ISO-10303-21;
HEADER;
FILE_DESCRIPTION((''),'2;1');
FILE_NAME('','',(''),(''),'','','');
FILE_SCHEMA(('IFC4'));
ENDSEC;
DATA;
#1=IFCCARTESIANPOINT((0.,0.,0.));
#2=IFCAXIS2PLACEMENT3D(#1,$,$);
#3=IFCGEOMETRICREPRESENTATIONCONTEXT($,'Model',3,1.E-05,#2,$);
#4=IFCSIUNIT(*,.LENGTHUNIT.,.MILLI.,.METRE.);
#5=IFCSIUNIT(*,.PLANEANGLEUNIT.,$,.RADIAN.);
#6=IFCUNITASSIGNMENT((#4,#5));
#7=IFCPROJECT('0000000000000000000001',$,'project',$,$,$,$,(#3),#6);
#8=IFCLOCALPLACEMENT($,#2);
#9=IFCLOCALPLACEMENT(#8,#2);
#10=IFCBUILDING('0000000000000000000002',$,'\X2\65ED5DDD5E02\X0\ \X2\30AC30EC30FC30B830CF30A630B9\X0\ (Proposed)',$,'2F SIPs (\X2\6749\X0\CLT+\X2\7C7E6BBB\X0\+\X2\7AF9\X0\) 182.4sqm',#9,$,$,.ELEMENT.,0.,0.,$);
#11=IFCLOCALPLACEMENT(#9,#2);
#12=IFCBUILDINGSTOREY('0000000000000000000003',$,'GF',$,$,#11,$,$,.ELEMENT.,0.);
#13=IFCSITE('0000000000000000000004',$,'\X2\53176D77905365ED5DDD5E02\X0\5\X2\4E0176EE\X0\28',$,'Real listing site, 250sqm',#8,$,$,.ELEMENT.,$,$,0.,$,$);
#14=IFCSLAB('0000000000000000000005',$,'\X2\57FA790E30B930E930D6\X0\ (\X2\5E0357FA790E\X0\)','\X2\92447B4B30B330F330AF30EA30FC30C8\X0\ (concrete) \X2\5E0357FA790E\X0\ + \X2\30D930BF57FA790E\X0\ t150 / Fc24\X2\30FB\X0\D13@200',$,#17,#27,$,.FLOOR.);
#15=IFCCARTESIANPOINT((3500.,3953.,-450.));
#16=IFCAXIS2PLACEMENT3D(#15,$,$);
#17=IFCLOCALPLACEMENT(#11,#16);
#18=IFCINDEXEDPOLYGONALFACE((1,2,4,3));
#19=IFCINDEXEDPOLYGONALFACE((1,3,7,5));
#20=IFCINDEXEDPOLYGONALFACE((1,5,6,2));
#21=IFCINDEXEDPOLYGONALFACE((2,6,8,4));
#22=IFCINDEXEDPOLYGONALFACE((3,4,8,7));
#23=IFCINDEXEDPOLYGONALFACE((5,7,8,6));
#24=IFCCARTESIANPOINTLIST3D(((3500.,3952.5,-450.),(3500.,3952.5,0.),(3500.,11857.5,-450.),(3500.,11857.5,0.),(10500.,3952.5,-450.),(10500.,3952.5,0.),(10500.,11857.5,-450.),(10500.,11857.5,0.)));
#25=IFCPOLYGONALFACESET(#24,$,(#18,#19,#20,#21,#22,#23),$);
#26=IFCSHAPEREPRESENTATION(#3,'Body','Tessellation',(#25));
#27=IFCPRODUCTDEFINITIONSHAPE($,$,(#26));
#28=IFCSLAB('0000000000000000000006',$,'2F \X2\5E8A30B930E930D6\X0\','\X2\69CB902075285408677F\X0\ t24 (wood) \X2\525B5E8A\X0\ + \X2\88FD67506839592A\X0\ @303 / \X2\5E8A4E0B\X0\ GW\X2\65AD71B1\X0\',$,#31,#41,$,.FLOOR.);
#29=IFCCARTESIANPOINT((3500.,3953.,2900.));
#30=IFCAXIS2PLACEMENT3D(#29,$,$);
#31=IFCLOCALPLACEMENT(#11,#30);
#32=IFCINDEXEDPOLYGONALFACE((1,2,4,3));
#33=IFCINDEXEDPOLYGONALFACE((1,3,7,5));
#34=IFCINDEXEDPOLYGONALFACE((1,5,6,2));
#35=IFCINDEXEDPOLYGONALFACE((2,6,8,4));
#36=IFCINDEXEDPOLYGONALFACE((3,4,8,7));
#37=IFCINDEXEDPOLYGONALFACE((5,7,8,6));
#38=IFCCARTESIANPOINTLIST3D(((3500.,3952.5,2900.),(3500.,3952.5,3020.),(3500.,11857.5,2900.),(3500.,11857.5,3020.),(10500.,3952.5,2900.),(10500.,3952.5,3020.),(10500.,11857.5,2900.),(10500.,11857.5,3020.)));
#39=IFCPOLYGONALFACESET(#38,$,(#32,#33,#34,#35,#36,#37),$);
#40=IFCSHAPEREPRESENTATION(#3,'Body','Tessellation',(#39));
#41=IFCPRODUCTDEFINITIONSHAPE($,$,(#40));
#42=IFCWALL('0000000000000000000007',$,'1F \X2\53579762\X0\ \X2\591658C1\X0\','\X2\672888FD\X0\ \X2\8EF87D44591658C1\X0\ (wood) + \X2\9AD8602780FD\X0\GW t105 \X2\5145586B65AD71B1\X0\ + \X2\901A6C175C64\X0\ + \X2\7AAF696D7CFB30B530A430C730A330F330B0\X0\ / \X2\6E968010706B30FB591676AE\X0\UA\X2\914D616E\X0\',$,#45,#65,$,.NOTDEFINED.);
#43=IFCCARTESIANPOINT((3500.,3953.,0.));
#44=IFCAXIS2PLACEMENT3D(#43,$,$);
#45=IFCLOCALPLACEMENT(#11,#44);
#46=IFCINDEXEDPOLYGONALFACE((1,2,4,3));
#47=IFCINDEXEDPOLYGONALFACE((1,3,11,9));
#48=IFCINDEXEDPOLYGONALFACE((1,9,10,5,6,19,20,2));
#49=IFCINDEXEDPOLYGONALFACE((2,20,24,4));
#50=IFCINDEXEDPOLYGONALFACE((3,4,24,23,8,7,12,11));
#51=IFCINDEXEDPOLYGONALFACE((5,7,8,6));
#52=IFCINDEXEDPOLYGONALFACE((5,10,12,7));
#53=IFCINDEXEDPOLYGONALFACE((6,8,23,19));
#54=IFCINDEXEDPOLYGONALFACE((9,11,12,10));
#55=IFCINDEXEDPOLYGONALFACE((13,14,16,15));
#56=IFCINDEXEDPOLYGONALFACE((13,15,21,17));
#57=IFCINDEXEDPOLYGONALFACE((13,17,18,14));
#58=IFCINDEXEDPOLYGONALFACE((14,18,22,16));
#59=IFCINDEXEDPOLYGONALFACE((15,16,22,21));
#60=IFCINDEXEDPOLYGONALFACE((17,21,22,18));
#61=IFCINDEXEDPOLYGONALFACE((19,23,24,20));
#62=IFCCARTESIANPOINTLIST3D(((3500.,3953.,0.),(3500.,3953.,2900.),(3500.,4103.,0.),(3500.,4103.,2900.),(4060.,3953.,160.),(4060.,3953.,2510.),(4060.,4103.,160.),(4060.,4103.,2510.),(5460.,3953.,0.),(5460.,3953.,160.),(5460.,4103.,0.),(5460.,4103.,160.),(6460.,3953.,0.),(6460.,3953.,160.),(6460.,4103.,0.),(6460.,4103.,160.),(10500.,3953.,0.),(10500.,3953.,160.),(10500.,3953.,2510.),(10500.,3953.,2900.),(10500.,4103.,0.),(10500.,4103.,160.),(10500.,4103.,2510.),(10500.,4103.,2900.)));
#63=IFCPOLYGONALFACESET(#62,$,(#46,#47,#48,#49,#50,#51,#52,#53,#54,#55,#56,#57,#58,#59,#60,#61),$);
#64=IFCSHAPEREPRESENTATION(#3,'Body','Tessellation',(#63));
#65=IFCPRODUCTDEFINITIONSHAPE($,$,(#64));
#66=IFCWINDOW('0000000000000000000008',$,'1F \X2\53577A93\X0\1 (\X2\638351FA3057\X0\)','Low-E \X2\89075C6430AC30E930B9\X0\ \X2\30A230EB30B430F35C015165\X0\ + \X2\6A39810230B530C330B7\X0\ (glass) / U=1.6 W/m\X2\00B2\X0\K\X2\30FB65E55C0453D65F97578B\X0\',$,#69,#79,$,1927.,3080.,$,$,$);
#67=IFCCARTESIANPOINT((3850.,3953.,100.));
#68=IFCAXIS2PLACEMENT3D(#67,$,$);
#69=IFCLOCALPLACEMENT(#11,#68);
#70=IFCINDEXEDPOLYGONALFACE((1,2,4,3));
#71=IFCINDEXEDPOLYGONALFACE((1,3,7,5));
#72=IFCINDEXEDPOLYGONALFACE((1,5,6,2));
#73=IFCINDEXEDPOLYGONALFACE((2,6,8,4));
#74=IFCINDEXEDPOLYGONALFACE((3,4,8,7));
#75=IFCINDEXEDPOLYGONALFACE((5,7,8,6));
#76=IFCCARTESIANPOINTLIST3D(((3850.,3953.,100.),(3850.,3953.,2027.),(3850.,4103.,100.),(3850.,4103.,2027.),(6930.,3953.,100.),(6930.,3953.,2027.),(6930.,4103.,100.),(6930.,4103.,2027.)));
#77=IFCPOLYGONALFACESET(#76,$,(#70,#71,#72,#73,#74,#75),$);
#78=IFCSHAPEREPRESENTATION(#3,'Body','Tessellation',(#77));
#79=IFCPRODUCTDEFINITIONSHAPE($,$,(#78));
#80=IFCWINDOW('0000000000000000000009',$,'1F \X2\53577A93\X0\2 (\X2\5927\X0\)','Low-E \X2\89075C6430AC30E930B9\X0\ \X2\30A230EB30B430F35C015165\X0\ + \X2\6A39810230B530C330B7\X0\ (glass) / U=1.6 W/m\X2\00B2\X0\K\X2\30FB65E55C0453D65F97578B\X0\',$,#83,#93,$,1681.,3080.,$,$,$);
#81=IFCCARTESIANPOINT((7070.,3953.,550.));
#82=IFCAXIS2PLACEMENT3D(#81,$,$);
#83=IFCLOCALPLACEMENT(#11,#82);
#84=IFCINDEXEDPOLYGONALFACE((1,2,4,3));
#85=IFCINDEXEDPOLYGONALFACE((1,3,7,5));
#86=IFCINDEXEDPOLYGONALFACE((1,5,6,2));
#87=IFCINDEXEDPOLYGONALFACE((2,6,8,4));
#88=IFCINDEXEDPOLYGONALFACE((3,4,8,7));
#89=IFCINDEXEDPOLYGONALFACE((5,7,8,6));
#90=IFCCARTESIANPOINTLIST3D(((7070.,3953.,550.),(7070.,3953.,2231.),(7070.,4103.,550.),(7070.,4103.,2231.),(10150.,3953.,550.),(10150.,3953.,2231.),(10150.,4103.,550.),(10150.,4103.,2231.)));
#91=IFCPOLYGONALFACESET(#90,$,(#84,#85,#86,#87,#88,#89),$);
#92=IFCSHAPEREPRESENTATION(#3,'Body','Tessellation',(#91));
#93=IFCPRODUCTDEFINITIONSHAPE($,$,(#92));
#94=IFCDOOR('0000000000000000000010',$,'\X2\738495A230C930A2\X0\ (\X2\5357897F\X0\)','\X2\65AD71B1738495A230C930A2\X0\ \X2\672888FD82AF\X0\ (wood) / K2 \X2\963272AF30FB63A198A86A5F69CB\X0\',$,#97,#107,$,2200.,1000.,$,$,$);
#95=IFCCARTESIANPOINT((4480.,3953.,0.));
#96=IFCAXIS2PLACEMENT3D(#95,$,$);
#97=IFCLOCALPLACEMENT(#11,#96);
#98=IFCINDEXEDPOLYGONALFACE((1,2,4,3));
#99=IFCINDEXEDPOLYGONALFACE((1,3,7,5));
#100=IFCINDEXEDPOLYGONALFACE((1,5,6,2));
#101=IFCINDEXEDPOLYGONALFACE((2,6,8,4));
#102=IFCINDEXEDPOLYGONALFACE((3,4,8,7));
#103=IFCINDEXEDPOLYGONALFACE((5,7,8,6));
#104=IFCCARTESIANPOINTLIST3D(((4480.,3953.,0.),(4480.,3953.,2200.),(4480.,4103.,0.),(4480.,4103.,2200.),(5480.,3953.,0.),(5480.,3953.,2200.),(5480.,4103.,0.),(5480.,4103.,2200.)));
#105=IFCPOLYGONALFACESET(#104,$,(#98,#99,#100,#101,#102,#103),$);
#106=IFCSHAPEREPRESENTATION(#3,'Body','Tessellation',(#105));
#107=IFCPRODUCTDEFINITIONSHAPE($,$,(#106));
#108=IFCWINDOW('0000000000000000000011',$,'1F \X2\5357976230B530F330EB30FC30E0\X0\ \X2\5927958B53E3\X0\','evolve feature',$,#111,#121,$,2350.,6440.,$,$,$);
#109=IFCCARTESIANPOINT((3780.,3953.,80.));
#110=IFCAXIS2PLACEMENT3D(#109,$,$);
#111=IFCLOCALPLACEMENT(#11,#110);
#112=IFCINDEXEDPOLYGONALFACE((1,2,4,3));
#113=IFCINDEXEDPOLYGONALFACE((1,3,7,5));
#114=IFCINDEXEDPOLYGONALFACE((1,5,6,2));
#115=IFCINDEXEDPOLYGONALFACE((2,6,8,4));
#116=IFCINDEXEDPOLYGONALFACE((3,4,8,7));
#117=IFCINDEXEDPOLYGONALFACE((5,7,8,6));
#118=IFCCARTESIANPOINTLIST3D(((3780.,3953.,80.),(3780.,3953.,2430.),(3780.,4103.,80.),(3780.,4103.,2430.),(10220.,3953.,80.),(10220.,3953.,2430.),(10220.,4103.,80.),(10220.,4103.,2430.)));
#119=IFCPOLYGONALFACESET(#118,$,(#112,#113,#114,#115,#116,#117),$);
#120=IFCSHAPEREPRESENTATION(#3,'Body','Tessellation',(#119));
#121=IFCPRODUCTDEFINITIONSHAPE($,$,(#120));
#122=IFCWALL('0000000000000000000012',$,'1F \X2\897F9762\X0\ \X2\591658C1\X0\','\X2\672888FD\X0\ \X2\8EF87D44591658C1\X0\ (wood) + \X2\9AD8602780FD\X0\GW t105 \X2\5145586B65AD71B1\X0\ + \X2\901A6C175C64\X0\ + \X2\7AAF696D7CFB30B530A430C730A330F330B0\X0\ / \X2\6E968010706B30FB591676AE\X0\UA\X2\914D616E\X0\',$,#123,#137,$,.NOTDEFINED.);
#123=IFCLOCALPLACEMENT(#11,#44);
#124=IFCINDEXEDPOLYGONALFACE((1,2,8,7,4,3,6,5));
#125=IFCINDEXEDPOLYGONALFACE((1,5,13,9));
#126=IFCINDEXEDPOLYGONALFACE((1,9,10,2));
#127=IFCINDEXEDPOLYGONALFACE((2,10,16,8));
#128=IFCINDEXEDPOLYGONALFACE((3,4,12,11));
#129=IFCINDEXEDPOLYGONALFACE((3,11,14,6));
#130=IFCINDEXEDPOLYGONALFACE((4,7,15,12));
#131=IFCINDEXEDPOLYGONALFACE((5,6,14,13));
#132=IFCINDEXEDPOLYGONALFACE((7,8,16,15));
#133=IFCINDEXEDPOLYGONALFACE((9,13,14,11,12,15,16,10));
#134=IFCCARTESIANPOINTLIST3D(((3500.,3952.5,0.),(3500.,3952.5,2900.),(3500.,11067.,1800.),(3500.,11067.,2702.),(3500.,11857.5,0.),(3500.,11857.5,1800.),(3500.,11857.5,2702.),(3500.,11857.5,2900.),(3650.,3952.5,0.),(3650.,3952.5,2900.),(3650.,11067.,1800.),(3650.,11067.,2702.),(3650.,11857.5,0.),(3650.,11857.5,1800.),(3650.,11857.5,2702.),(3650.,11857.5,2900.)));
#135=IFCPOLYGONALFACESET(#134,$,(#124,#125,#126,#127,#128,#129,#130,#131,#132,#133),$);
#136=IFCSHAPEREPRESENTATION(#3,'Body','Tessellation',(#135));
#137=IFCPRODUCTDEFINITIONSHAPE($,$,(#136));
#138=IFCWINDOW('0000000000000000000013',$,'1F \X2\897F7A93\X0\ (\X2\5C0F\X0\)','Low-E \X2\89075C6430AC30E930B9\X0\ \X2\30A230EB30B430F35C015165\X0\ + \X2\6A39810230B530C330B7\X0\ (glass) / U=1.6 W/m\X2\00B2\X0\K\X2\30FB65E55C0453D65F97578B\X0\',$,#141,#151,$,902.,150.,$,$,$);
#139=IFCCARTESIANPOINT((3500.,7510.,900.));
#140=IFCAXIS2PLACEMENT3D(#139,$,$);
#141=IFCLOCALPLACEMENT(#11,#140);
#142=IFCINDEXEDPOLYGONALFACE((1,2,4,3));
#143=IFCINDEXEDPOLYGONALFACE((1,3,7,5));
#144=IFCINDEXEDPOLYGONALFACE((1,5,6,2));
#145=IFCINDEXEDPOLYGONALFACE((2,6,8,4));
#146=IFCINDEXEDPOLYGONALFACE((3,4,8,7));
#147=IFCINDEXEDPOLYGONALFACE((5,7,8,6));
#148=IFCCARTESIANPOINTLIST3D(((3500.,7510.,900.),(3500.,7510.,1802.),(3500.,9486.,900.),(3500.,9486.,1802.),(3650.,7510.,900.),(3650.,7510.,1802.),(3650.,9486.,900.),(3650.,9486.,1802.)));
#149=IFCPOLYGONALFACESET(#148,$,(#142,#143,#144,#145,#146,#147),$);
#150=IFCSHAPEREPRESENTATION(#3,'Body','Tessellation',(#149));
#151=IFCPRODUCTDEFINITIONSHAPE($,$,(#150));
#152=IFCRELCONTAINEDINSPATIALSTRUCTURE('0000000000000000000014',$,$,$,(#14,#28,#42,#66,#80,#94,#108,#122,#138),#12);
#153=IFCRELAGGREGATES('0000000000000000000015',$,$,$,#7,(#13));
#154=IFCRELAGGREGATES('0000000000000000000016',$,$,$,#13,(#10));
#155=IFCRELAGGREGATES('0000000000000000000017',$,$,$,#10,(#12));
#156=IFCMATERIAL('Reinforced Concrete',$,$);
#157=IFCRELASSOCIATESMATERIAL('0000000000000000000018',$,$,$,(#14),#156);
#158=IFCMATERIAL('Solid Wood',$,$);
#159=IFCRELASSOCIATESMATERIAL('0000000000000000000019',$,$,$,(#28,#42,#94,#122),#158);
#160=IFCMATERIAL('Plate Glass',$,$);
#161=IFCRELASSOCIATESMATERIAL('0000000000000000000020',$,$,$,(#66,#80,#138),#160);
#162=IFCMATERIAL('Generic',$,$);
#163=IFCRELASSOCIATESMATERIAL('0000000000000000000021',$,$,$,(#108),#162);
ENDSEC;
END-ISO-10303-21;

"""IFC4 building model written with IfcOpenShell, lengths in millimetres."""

from ifc_helpers import new_model, si_unit, frame, frame_2d, origin, place, context, project, spatial, rectangle, extrude, material, element, fill, save


model = new_model("IFC4")

# Units and contexts
model_context = context("Model", 3, precision=1e-05, world=origin())
ifc_project = project(units=[si_unit("LENGTHUNIT", "METRE", prefix="MILLI"), si_unit("PLANEANGLEUNIT", "RADIAN")], contexts=[model_context])

# Site, building, storey
site_placement = place(None, origin())
site = spatial("IfcSite", under=ifc_project, at=site_placement, Name="北海道旭川市5丁目28", ObjectType="Real listing site, 250sqm", CompositionType="ELEMENT", RefElevation=0.0)
building_placement = place(site_placement, origin())
building = spatial("IfcBuilding", under=site, at=building_placement, Name="旭川市 ガレージハウス (Proposed)", ObjectType="2F SIPs (杉CLT+籾殻+竹) 182.4sqm", CompositionType="ELEMENT", ElevationOfRefHeight=0.0, ElevationOfTerrain=0.0)
storey_placement = place(building_placement, origin())
storey = spatial("IfcBuildingStorey", under=building, at=storey_placement, Name="GF", CompositionType="ELEMENT", Elevation=0.0)

# Slabs
ifc_material_1 = material(Name="Reinforced Concrete")
slab_1_placement = place(storey_placement, frame((3500.0, 3953.0, -450.0)))
element("IfcSlab", 1, at=slab_1_placement, inside=storey, material=ifc_material_1, Name="基礎スラブ (布基礎)", Description="鉄筋コンクリート (concrete) 布基礎 + ベタ基礎 t150 / Fc24・D13@200", PredefinedType="FLOOR", context=model_context, shape_type="SweptSolid", body=[
    extrude(rectangle(XDim=7000.0, YDim=7905.0, at=frame_2d((3500.0, 3952.0))), frame((3500.0, 3953.0, -450.0)), (0.0, 0.0, 1.0), 450.0),
])
ifc_material_2 = material(Name="Solid Wood")
slab_2_placement = place(storey_placement, frame((3500.0, 3953.0, 2900.0)))
element("IfcSlab", 2, at=slab_2_placement, inside=storey, material=ifc_material_2, Name="2F 床スラブ", Description="構造用合板 t24 (wood) 剛床 + 製材根太 @303 / 床下 GW断熱", PredefinedType="FLOOR", context=model_context, shape_type="SweptSolid", body=[
    extrude(rectangle(XDim=7000.0, YDim=7905.0, at=frame_2d((3500.0, 3952.0))), frame((3500.0, 3953.0, 2900.0)), (0.0, 0.0, 1.0), 120.0),
])
ifc_material_3 = material(Name="Generic")

# Wall, openings, windows, door
wall_1_placement = place(storey_placement, frame((3500.0, 3953.0, 0.0)))
wall_1 = element("IfcWall", 3, at=wall_1_placement, inside=storey, material=ifc_material_2, Name="1F 南面 外壁", Description="木製 軸組外壁 (wood) + 高性能GW t105 充填断熱 + 通気層 + 窯業系サイディング / 準耐火・外皮UA配慮", PredefinedType="NOTDEFINED", context=model_context, shape_type="SweptSolid", body=[
    extrude(rectangle(XDim=7000.0, YDim=150.0, at=frame_2d((3500.0, 75.0))), frame((3500.0, 3953.0, 0.0)), (0.0, 0.0, 1.0), 2900.0),
])
opening_1_placement = place(storey_placement, frame((3850.0, 3953.0, 100.0)))
opening_1 = element("IfcOpeningElement", 4, at=opening_1_placement, cuts=wall_1, PredefinedType="NOTDEFINED", context=model_context, shape_type="SweptSolid", body=[
    extrude(rectangle(XDim=3080.0, YDim=150.0, at=frame_2d((1540.0, 75.0))), frame((3850.0, 3953.0, 100.0)), (0.0, 0.0, 1.0), 1927.0),
])
opening_2_placement = place(storey_placement, frame((7070.0, 3953.0, 550.0)))
opening_2 = element("IfcOpeningElement", 5, at=opening_2_placement, cuts=wall_1, PredefinedType="NOTDEFINED", context=model_context, shape_type="SweptSolid", body=[
    extrude(rectangle(XDim=3080.0, YDim=150.0, at=frame_2d((1540.0, 75.0))), frame((7070.0, 3953.0, 550.0)), (0.0, 0.0, 1.0), 1681.0),
])
opening_3_placement = place(storey_placement, frame((4480.0, 3953.0, 0.0)))
opening_3 = element("IfcOpeningElement", 6, at=opening_3_placement, cuts=wall_1, PredefinedType="NOTDEFINED", context=model_context, shape_type="SweptSolid", body=[
    extrude(rectangle(XDim=1000.0, YDim=150.0, at=frame_2d((500.0, 75.0))), frame((4480.0, 3953.0, 0.0)), (0.0, 0.0, 1.0), 2200.0),
])
opening_4_placement = place(storey_placement, frame((3780.0, 3953.0, 80.0)))
opening_4 = element("IfcOpeningElement", 7, at=opening_4_placement, cuts=wall_1, PredefinedType="NOTDEFINED", context=model_context, shape_type="SweptSolid", body=[
    extrude(rectangle(XDim=6440.0, YDim=150.0, at=frame_2d((3220.0, 75.0))), frame((3780.0, 3953.0, 80.0)), (0.0, 0.0, 1.0), 2350.0),
])
ifc_material_4 = material(Name="Plate Glass")
window_1_placement = place(storey_placement, frame((3850.0, 3953.0, 100.0)))
window_1 = element("IfcWindow", 8, at=window_1_placement, inside=storey, material=ifc_material_4, Name="1F 南窓1 (掃出し)", Description="Low-E 複層ガラス アルゴン封入 + 樹脂サッシ (glass) / U=1.6 W/m²K・日射取得型", OverallHeight=1927.0, OverallWidth=3080.0, context=model_context, shape_type="SweptSolid", body=[
    extrude(rectangle(XDim=3080.0, YDim=150.0, at=frame_2d((1540.0, 75.0))), frame((3850.0, 3953.0, 100.0)), (0.0, 0.0, 1.0), 1927.0),
])
fill(opening_1, window_1)
window_2_placement = place(storey_placement, frame((7070.0, 3953.0, 550.0)))
window_2 = element("IfcWindow", 9, at=window_2_placement, inside=storey, material=ifc_material_4, Name="1F 南窓2 (大)", Description="Low-E 複層ガラス アルゴン封入 + 樹脂サッシ (glass) / U=1.6 W/m²K・日射取得型", OverallHeight=1681.0, OverallWidth=3080.0, context=model_context, shape_type="SweptSolid", body=[
    extrude(rectangle(XDim=3080.0, YDim=150.0, at=frame_2d((1540.0, 75.0))), frame((7070.0, 3953.0, 550.0)), (0.0, 0.0, 1.0), 1681.0),
])
fill(opening_2, window_2)
door_placement = place(storey_placement, frame((4480.0, 3953.0, 0.0)))
door = element("IfcDoor", 10, at=door_placement, inside=storey, material=ifc_material_2, Name="玄関ドア (南西)", Description="断熱玄関ドア 木製芯 (wood) / K2 防犯・採風機構", OverallHeight=2200.0, OverallWidth=1000.0, context=model_context, shape_type="SweptSolid", body=[
    extrude(rectangle(XDim=1000.0, YDim=150.0, at=frame_2d((500.0, 75.0))), frame((4480.0, 3953.0, 0.0)), (0.0, 0.0, 1.0), 2200.0),
])
fill(opening_3, door)
window_3_placement = place(storey_placement, frame((3780.0, 3953.0, 80.0)))
window_3 = element("IfcWindow", 11, at=window_3_placement, inside=storey, material=ifc_material_3, Name="1F 南面サンルーム 大開口", Description="evolve feature", OverallHeight=2350.0, OverallWidth=6440.0, context=model_context, shape_type="SweptSolid", body=[
    extrude(rectangle(XDim=6440.0, YDim=150.0, at=frame_2d((3220.0, 75.0))), frame((3780.0, 3953.0, 80.0)), (0.0, 0.0, 1.0), 2350.0),
])
fill(opening_4, window_3)

# Wall, opening, window
wall_2_placement = place(storey_placement, frame((3500.0, 3953.0, 0.0)))
wall_2 = element("IfcWall", 12, at=wall_2_placement, inside=storey, material=ifc_material_2, Name="1F 西面 外壁", Description="木製 軸組外壁 (wood) + 高性能GW t105 充填断熱 + 通気層 + 窯業系サイディング / 準耐火・外皮UA配慮", PredefinedType="NOTDEFINED", context=model_context, shape_type="SweptSolid", body=[
    extrude(rectangle(XDim=150.0, YDim=7905.0, at=frame_2d((75.0, 3952.0))), frame((3500.0, 3953.0, 0.0)), (0.0, 0.0, 1.0), 2900.0),
])
opening_5_placement = place(storey_placement, frame((3500.0, 7510.0, 900.0)))
opening_5 = element("IfcOpeningElement", 13, at=opening_5_placement, cuts=wall_2, PredefinedType="NOTDEFINED", context=model_context, shape_type="SweptSolid", body=[
    extrude(rectangle(XDim=150.0, YDim=1976.0, at=frame_2d((75.0, 988.0))), frame((3500.0, 7510.0, 900.0)), (0.0, 0.0, 1.0), 902.0),
])
window_4_placement = place(storey_placement, frame((3500.0, 7510.0, 900.0)))
window_4 = element("IfcWindow", 14, at=window_4_placement, inside=storey, material=ifc_material_4, Name="1F 西窓 (小)", Description="Low-E 複層ガラス アルゴン封入 + 樹脂サッシ (glass) / U=1.6 W/m²K・日射取得型", OverallHeight=902.0, OverallWidth=150.0, context=model_context, shape_type="SweptSolid", body=[
    extrude(rectangle(XDim=150.0, YDim=1976.0, at=frame_2d((75.0, 988.0))), frame((3500.0, 7510.0, 900.0)), (0.0, 0.0, 1.0), 902.0),
])
fill(opening_5, window_4)

save(model, "model.ifc")
